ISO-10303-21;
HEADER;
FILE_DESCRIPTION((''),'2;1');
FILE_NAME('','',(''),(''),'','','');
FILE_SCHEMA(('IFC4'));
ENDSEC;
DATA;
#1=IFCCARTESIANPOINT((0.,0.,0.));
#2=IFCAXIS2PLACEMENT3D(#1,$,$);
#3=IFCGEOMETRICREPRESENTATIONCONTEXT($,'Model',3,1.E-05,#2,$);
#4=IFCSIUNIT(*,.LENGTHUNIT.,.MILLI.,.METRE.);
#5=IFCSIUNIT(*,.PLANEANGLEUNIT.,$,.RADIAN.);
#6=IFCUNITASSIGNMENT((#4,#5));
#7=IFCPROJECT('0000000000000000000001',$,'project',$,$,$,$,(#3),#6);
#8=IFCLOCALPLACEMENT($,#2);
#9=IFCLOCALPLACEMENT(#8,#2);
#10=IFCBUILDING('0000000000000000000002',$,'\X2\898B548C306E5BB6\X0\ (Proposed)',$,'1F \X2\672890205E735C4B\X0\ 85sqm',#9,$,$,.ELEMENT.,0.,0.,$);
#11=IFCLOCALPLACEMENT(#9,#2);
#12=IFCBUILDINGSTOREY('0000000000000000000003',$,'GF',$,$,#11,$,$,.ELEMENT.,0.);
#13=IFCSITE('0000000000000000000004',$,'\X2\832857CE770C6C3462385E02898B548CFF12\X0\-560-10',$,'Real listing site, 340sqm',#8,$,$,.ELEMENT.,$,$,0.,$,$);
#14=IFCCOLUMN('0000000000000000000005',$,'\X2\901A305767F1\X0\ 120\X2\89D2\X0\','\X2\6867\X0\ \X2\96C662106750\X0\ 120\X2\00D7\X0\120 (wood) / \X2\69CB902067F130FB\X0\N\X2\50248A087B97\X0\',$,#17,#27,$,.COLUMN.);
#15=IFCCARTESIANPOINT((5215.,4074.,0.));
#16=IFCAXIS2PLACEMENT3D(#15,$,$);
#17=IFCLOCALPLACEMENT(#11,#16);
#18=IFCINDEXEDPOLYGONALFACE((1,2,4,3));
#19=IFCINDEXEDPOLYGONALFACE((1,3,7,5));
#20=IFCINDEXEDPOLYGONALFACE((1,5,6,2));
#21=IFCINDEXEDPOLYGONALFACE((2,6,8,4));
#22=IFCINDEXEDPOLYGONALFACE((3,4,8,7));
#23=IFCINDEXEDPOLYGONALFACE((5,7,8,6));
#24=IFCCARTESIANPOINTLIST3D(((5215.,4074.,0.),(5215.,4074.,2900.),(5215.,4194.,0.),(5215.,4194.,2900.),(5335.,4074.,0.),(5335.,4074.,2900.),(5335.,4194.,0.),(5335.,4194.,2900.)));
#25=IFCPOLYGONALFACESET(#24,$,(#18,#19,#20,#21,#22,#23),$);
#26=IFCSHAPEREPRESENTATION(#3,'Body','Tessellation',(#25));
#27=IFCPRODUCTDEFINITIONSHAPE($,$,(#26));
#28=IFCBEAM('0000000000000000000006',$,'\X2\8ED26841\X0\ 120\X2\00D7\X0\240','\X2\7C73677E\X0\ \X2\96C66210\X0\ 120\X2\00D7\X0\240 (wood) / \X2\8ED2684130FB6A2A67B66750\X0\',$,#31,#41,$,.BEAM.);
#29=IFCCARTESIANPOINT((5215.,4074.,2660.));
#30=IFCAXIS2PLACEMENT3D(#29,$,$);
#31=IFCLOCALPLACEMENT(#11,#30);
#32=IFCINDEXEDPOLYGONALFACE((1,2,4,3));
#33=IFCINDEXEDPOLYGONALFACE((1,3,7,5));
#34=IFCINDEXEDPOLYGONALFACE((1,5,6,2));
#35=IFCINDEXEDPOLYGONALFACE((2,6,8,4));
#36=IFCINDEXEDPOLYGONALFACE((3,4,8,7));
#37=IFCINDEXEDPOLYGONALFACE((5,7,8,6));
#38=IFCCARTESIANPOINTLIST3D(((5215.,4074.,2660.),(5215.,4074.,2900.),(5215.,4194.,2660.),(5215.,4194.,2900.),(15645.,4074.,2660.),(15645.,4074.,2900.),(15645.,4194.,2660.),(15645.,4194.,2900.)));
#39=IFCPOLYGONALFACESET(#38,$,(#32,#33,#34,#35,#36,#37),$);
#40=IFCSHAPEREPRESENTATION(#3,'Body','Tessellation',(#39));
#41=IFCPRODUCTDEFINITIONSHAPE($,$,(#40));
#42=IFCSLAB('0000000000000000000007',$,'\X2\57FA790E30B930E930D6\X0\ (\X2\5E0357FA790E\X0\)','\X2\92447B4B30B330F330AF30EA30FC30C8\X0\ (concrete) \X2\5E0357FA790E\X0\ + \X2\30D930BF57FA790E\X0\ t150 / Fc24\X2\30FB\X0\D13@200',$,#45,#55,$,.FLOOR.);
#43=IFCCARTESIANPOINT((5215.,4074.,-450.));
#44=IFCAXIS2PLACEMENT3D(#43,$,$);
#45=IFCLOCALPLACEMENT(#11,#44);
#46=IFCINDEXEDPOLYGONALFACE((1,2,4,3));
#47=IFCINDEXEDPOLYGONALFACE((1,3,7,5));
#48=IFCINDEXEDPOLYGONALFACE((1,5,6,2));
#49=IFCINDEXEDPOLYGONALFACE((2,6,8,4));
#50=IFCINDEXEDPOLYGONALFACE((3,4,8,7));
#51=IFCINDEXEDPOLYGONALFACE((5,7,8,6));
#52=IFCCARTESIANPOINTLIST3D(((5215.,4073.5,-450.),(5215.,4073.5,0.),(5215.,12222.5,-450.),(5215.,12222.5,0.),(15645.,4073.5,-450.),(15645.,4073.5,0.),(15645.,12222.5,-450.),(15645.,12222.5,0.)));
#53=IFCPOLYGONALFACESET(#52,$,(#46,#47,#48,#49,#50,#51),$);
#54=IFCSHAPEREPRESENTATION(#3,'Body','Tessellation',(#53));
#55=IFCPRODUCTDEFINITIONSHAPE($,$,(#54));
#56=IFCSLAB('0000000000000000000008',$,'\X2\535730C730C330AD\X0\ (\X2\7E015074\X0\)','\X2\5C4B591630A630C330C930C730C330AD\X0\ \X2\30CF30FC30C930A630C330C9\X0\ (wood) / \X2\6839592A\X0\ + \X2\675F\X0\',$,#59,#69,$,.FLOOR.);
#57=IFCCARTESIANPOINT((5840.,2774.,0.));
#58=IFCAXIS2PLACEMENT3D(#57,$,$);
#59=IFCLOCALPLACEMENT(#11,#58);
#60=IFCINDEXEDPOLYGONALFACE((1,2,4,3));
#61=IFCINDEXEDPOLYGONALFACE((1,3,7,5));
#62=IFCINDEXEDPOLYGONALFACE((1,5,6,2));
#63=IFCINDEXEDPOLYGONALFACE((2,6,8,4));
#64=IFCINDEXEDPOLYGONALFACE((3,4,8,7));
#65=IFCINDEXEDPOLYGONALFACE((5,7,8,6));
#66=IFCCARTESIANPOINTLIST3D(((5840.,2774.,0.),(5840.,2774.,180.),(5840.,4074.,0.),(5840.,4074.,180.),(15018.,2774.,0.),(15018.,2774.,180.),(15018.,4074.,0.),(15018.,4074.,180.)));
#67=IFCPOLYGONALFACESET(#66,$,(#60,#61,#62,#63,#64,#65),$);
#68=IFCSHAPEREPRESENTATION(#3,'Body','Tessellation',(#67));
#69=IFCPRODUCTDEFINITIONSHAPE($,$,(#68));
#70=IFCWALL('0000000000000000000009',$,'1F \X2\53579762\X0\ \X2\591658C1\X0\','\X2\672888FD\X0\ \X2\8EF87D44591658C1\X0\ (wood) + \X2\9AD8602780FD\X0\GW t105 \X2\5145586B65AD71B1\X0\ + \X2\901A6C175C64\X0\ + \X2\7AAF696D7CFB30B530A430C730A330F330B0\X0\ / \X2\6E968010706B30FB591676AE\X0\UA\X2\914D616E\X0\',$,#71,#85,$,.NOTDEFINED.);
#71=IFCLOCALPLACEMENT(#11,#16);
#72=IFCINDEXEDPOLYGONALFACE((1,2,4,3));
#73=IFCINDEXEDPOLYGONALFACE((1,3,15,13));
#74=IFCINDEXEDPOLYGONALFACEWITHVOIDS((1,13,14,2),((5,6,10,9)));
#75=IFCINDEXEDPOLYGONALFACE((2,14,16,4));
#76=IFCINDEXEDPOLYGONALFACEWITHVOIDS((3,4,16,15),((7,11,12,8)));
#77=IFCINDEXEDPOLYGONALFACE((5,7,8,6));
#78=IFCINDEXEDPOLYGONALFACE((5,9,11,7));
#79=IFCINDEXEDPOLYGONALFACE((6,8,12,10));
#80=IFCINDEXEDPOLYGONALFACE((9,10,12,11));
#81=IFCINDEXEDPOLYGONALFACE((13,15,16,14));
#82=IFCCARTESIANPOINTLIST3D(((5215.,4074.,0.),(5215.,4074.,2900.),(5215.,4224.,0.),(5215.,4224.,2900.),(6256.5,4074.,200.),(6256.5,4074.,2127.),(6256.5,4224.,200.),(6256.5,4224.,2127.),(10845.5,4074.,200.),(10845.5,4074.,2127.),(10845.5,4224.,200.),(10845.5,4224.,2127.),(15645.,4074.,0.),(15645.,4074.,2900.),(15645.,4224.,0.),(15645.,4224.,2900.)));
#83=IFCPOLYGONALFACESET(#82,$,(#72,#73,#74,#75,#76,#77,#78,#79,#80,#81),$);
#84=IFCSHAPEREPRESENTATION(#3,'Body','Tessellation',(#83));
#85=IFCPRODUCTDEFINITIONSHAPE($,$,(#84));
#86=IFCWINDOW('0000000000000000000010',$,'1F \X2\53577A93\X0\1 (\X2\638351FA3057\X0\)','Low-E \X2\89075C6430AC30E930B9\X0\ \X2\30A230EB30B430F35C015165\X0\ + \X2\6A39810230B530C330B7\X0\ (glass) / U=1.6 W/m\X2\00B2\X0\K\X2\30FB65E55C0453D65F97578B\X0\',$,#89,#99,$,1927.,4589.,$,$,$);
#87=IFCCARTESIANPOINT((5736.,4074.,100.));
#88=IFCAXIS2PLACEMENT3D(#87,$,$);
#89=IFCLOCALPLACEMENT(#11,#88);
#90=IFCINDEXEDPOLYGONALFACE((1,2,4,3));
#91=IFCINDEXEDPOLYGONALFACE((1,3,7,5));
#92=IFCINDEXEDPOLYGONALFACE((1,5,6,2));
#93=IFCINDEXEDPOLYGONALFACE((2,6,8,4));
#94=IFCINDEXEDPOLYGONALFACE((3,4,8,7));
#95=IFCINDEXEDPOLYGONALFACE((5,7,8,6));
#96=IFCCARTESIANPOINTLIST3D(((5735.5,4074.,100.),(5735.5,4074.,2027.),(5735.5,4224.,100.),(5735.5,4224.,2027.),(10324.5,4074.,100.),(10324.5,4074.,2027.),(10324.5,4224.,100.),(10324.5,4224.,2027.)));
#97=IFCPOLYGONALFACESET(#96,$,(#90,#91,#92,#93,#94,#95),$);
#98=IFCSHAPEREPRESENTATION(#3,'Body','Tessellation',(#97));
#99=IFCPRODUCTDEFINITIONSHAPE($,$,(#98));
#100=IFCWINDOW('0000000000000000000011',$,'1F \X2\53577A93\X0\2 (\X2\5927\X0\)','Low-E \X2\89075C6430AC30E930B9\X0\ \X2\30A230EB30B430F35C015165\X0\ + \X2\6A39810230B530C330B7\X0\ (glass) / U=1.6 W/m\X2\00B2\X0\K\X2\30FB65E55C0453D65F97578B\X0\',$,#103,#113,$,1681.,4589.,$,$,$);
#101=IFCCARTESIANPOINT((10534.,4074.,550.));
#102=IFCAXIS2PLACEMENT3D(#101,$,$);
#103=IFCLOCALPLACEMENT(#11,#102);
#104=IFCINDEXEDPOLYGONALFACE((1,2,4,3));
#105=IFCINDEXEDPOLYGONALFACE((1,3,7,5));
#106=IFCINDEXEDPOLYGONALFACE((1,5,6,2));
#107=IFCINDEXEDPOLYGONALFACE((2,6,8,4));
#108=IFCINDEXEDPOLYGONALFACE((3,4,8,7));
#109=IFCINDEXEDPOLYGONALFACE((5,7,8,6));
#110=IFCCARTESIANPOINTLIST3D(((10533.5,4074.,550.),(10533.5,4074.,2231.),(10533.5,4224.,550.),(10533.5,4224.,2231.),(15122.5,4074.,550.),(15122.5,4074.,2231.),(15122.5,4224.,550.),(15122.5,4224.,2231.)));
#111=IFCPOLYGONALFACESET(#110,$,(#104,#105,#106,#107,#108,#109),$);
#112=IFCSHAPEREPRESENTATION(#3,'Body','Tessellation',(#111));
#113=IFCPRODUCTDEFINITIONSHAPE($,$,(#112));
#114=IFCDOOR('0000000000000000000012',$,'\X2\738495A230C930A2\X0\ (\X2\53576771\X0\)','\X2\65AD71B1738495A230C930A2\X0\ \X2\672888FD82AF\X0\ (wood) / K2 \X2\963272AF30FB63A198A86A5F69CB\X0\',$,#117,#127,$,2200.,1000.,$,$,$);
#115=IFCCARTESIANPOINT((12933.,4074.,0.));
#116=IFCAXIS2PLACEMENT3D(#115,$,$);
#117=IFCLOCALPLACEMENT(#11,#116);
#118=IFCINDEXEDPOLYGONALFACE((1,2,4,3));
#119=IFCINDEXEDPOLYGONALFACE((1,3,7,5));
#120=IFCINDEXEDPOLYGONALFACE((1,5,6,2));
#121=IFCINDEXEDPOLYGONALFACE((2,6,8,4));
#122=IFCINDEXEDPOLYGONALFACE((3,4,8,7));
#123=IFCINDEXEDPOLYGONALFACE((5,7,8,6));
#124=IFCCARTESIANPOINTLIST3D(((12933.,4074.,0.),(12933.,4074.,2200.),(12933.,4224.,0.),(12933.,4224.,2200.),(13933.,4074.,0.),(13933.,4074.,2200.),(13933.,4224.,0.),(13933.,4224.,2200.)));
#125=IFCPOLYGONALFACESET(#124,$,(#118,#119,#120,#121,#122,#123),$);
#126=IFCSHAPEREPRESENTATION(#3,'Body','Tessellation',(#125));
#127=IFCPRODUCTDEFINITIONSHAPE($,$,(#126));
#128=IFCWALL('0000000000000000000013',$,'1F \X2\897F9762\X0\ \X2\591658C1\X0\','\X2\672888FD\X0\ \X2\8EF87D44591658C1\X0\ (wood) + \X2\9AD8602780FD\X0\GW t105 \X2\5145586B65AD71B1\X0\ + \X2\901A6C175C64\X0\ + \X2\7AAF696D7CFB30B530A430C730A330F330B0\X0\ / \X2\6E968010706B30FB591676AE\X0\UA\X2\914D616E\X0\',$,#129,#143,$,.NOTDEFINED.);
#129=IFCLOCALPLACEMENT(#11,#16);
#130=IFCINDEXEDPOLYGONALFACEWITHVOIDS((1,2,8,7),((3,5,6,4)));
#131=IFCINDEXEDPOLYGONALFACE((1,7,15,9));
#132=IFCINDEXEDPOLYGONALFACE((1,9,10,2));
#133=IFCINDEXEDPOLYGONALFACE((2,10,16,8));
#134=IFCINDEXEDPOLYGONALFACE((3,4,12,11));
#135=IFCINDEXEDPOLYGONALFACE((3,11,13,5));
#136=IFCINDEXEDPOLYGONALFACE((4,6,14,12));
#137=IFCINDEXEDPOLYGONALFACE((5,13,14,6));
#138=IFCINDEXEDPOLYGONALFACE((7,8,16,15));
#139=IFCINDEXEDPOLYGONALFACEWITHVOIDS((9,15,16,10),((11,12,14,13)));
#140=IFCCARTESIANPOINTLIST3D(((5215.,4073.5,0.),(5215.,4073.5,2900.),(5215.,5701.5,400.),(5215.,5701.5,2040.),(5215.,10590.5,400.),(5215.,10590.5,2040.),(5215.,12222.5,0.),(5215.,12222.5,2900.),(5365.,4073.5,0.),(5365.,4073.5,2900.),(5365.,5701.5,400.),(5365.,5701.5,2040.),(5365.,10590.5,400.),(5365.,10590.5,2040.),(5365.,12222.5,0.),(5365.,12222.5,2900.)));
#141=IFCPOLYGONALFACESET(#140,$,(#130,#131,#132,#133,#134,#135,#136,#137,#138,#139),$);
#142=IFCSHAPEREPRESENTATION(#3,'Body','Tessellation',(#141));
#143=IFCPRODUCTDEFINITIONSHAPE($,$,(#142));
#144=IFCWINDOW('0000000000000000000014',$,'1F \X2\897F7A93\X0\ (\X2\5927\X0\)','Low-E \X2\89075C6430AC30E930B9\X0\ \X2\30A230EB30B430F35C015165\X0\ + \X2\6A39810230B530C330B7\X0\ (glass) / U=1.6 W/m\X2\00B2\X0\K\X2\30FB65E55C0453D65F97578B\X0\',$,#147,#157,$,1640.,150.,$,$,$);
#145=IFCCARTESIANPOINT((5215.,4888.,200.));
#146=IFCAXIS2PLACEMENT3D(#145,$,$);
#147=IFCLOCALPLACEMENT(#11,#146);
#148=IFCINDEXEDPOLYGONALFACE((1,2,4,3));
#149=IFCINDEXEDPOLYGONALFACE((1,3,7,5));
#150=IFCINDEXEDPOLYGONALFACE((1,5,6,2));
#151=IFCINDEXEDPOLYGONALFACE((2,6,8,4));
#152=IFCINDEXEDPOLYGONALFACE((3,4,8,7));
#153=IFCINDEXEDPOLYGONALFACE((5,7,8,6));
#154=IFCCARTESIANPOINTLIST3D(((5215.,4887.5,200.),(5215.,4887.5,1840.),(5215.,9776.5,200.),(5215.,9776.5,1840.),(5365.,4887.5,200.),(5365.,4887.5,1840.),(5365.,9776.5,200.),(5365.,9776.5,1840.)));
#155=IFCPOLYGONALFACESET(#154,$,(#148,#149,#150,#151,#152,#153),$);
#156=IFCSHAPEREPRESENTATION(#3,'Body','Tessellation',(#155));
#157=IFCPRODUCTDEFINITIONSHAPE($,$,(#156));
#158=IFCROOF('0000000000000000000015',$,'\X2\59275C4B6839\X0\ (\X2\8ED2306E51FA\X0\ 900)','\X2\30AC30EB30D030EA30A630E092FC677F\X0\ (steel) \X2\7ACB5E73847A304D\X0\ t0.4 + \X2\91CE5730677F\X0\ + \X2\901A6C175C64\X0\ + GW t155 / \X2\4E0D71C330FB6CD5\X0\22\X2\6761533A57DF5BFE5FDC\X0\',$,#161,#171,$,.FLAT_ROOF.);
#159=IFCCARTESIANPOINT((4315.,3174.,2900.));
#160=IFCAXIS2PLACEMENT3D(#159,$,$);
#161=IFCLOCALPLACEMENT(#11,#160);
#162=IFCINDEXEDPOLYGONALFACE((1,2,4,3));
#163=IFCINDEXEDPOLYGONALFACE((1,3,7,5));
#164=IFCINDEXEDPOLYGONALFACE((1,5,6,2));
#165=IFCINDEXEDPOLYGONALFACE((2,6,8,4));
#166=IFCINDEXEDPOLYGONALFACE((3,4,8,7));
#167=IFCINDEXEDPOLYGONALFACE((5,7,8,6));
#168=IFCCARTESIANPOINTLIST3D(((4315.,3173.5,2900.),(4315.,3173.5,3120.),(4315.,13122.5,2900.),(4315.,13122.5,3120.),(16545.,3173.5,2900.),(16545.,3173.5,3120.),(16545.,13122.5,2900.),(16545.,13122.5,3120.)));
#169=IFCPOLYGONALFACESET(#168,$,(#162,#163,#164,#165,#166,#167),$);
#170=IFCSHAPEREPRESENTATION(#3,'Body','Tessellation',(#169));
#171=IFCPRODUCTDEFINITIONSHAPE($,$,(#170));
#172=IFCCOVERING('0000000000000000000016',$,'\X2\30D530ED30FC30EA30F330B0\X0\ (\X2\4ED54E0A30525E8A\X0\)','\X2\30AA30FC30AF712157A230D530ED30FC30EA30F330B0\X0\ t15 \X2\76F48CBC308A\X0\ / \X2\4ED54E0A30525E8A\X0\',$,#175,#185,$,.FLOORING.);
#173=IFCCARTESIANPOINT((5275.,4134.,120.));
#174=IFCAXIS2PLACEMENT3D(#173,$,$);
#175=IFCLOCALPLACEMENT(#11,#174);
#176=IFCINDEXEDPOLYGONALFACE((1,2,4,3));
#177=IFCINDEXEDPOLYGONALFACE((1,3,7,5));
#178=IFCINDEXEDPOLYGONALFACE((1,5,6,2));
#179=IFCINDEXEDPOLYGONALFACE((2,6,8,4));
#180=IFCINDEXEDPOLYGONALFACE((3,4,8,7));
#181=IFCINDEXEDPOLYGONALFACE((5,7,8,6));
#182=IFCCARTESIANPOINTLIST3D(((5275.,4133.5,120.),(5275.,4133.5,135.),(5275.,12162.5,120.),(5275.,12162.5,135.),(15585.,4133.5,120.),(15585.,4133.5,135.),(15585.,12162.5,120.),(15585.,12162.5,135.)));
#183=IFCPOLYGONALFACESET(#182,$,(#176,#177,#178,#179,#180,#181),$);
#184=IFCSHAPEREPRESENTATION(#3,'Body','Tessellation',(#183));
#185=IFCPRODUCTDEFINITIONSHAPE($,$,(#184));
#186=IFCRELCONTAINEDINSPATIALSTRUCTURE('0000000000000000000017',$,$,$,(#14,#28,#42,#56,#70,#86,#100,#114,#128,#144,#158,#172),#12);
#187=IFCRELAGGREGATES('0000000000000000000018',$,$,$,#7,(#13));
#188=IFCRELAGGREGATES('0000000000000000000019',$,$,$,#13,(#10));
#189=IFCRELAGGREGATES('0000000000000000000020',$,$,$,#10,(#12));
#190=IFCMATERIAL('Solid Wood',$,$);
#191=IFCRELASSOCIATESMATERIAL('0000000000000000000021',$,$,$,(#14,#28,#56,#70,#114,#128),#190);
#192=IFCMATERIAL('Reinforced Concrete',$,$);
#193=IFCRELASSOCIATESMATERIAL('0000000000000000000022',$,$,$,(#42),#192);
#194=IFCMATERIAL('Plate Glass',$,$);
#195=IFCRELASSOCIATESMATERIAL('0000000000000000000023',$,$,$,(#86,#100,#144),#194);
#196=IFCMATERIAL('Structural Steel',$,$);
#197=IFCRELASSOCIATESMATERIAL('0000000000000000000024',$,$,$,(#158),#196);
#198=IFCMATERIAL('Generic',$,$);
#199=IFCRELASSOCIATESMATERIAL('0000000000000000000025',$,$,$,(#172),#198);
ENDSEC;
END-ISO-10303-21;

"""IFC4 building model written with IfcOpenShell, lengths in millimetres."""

from ifc_helpers import new_model, si_unit, frame, frame_2d, origin, place, context, project, spatial, rectangle, extrude, material, element, fill, save


model = new_model("IFC4")

# Units and contexts
model_context = context("Model", 3, precision=1e-05, world=origin())
ifc_project = project(units=[si_unit("LENGTHUNIT", "METRE", prefix="MILLI"), si_unit("PLANEANGLEUNIT", "RADIAN")], contexts=[model_context])

# Site, building, storey
site_placement = place(None, origin())
site = spatial("IfcSite", under=ifc_project, at=site_placement, Name="茨城県水戸市見和２-560-10", ObjectType="Real listing site, 340sqm", CompositionType="ELEMENT", RefElevation=0.0)
building_placement = place(site_placement, origin())
building = spatial("IfcBuilding", under=site, at=building_placement, Name="見和の家 (Proposed)", ObjectType="1F 木造平屋 85sqm", CompositionType="ELEMENT", ElevationOfRefHeight=0.0, ElevationOfTerrain=0.0)
storey_placement = place(building_placement, origin())
storey = spatial("IfcBuildingStorey", under=building, at=storey_placement, Name="GF", CompositionType="ELEMENT", Elevation=0.0)

# Column
ifc_material_1 = material(Name="Solid Wood")
column_placement = place(storey_placement, frame((5215.0, 4074.0, 0.0)))
element("IfcColumn", 1, at=column_placement, inside=storey, material=ifc_material_1, Name="通し柱 120角", Description="桧 集成材 120×120 (wood) / 構造柱・N値計算", PredefinedType="COLUMN", context=model_context, shape_type="SweptSolid", body=[
    extrude(rectangle(XDim=120.0, YDim=120.0, at=frame_2d((60.0, 60.0))), frame((5215.0, 4074.0, 0.0)), (0.0, 0.0, 1.0), 2900.0),
])

# Beam
beam_1_placement = place(storey_placement, frame((5215.0, 4074.0, 2660.0)))
element("IfcBeam", 2, at=beam_1_placement, inside=storey, material=ifc_material_1, Name="軒桁 120×240", Description="米松 集成 120×240 (wood) / 軒桁・横架材", PredefinedType="BEAM", context=model_context, shape_type="SweptSolid", body=[
    extrude(rectangle(XDim=10430.0, YDim=120.0, at=frame_2d((5215.0, 60.0))), frame((5215.0, 4074.0, 2660.0)), (0.0, 0.0, 1.0), 240.0),
])

# Slabs
ifc_material_2 = material(Name="Reinforced Concrete")
slab_1_placement = place(storey_placement, frame((5215.0, 4074.0, -450.0)))
element("IfcSlab", 3, at=slab_1_placement, inside=storey, material=ifc_material_2, Name="基礎スラブ (布基礎)", Description="鉄筋コンクリート (concrete) 布基礎 + ベタ基礎 t150 / Fc24・D13@200", PredefinedType="FLOOR", context=model_context, shape_type="SweptSolid", body=[
    extrude(rectangle(XDim=10430.0, YDim=8149.0, at=frame_2d((5215.0, 4074.0))), frame((5215.0, 4074.0, -450.0)), (0.0, 0.0, 1.0), 450.0),
])
slab_2_placement = place(storey_placement, frame((5840.0, 2774.0, 0.0)))
element("IfcSlab", 4, at=slab_2_placement, inside=storey, material=ifc_material_1, Name="南デッキ (縁側)", Description="屋外ウッドデッキ ハードウッド (wood) / 根太 + 束", PredefinedType="FLOOR", context=model_context, shape_type="SweptSolid", body=[
    extrude(rectangle(XDim=9178.0, YDim=1300.0, at=frame_2d((4589.0, 650.0))), frame((5840.0, 2774.0, 0.0)), (0.0, 0.0, 1.0), 180.0),
])

# Wall, openings, windows, door
wall_1_placement = place(storey_placement, frame((5215.0, 4074.0, 0.0)))
wall_1 = element("IfcWall", 5, at=wall_1_placement, inside=storey, material=ifc_material_1, Name="1F 南面 外壁", Description="木製 軸組外壁 (wood) + 高性能GW t105 充填断熱 + 通気層 + 窯業系サイディング / 準耐火・外皮UA配慮", PredefinedType="NOTDEFINED", context=model_context, shape_type="SweptSolid", body=[
    extrude(rectangle(XDim=10430.0, YDim=150.0, at=frame_2d((5215.0, 75.0))), frame((5215.0, 4074.0, 0.0)), (0.0, 0.0, 1.0), 2900.0),
])
opening_1_placement = place(storey_placement, frame((5736.0, 4074.0, 100.0)))
opening_1 = element("IfcOpeningElement", 6, at=opening_1_placement, cuts=wall_1, PredefinedType="NOTDEFINED", context=model_context, shape_type="SweptSolid", body=[
    extrude(rectangle(XDim=4589.0, YDim=150.0, at=frame_2d((2294.0, 75.0))), frame((5736.0, 4074.0, 100.0)), (0.0, 0.0, 1.0), 1927.0),
])
opening_2_placement = place(storey_placement, frame((10534.0, 4074.0, 550.0)))
opening_2 = element("IfcOpeningElement", 7, at=opening_2_placement, cuts=wall_1, PredefinedType="NOTDEFINED", context=model_context, shape_type="SweptSolid", body=[
    extrude(rectangle(XDim=4589.0, YDim=150.0, at=frame_2d((2294.0, 75.0))), frame((10534.0, 4074.0, 550.0)), (0.0, 0.0, 1.0), 1681.0),
])
opening_3_placement = place(storey_placement, frame((12933.0, 4074.0, 0.0)))
opening_3 = element("IfcOpeningElement", 8, at=opening_3_placement, cuts=wall_1, PredefinedType="NOTDEFINED", context=model_context, shape_type="SweptSolid", body=[
    extrude(rectangle(XDim=1000.0, YDim=150.0, at=frame_2d((500.0, 75.0))), frame((12933.0, 4074.0, 0.0)), (0.0, 0.0, 1.0), 2200.0),
])
ifc_material_3 = material(Name="Plate Glass")
window_1_placement = place(storey_placement, frame((5736.0, 4074.0, 100.0)))
window_1 = element("IfcWindow", 9, at=window_1_placement, inside=storey, material=ifc_material_3, Name="1F 南窓1 (掃出し)", Description="Low-E 複層ガラス アルゴン封入 + 樹脂サッシ (glass) / U=1.6 W/m²K・日射取得型", OverallHeight=1927.0, OverallWidth=4589.0, context=model_context, shape_type="SweptSolid", body=[
    extrude(rectangle(XDim=4589.0, YDim=150.0, at=frame_2d((2294.0, 75.0))), frame((5736.0, 4074.0, 100.0)), (0.0, 0.0, 1.0), 1927.0),
])
fill(opening_1, window_1)
window_2_placement = place(storey_placement, frame((10534.0, 4074.0, 550.0)))
window_2 = element("IfcWindow", 10, at=window_2_placement, inside=storey, material=ifc_material_3, Name="1F 南窓2 (大)", Description="Low-E 複層ガラス アルゴン封入 + 樹脂サッシ (glass) / U=1.6 W/m²K・日射取得型", OverallHeight=1681.0, OverallWidth=4589.0, context=model_context, shape_type="SweptSolid", body=[
    extrude(rectangle(XDim=4589.0, YDim=150.0, at=frame_2d((2294.0, 75.0))), frame((10534.0, 4074.0, 550.0)), (0.0, 0.0, 1.0), 1681.0),
])
fill(opening_2, window_2)
door_placement = place(storey_placement, frame((12933.0, 4074.0, 0.0)))
door = element("IfcDoor", 11, at=door_placement, inside=storey, material=ifc_material_1, Name="玄関ドア (南東)", Description="断熱玄関ドア 木製芯 (wood) / K2 防犯・採風機構", OverallHeight=2200.0, OverallWidth=1000.0, context=model_context, shape_type="SweptSolid", body=[
    extrude(rectangle(XDim=1000.0, YDim=150.0, at=frame_2d((500.0, 75.0))), frame((12933.0, 4074.0, 0.0)), (0.0, 0.0, 1.0), 2200.0),
])
fill(opening_3, door)

# Wall, opening, window
wall_2_placement = place(storey_placement, frame((5215.0, 4074.0, 0.0)))
wall_2 = element("IfcWall", 12, at=wall_2_placement, inside=storey, material=ifc_material_1, Name="1F 西面 外壁", Description="木製 軸組外壁 (wood) + 高性能GW t105 充填断熱 + 通気層 + 窯業系サイディング / 準耐火・外皮UA配慮", PredefinedType="NOTDEFINED", context=model_context, shape_type="SweptSolid", body=[
    extrude(rectangle(XDim=150.0, YDim=8149.0, at=frame_2d((75.0, 4074.0))), frame((5215.0, 4074.0, 0.0)), (0.0, 0.0, 1.0), 2900.0),
])
opening_4_placement = place(storey_placement, frame((5215.0, 4888.0, 200.0)))
opening_4 = element("IfcOpeningElement", 13, at=opening_4_placement, cuts=wall_2, PredefinedType="NOTDEFINED", context=model_context, shape_type="SweptSolid", body=[
    extrude(rectangle(XDim=150.0, YDim=4889.0, at=frame_2d((75.0, 2444.0))), frame((5215.0, 4888.0, 200.0)), (0.0, 0.0, 1.0), 1640.0),
])
window_3_placement = place(storey_placement, frame((5215.0, 4888.0, 200.0)))
window_3 = element("IfcWindow", 14, at=window_3_placement, inside=storey, material=ifc_material_3, Name="1F 西窓 (大)", Description="Low-E 複層ガラス アルゴン封入 + 樹脂サッシ (glass) / U=1.6 W/m²K・日射取得型", OverallHeight=1640.0, OverallWidth=150.0, context=model_context, shape_type="SweptSolid", body=[
    extrude(rectangle(XDim=150.0, YDim=4889.0, at=frame_2d((75.0, 2444.0))), frame((5215.0, 4888.0, 200.0)), (0.0, 0.0, 1.0), 1640.0),
])
fill(opening_4, window_3)

# Roof
ifc_material_4 = material(Name="Structural Steel")
roof_placement = place(storey_placement, frame((4315.0, 3174.0, 2900.0)))
element("IfcRoof", 15, at=roof_placement, inside=storey, material=ifc_material_4, Name="大屋根 (軒の出 900)", Description="ガルバリウム鋼板 (steel) 立平葺き t0.4 + 野地板 + 通気層 + GW t155 / 不燃・法22条区域対応", PredefinedType="FLAT_ROOF", context=model_context, shape_type="SweptSolid", body=[
    extrude(rectangle(XDim=12230.0, YDim=9949.0, at=frame_2d((6115.0, 4974.0))), frame((4315.0, 3174.0, 2900.0)), (0.0, 0.0, 1.0), 220.0),
])

# Covering
ifc_material_5 = material(Name="Generic")
covering_1_placement = place(storey_placement, frame((5275.0, 4134.0, 120.0)))
element("IfcCovering", 16, at=covering_1_placement, inside=storey, material=ifc_material_5, Name="フローリング (仕上げ床)", Description="オーク無垢フローリング t15 直貼り / 仕上げ床", PredefinedType="FLOORING", context=model_context, shape_type="SweptSolid", body=[
    extrude(rectangle(XDim=10310.0, YDim=8029.0, at=frame_2d((5155.0, 4014.0))), frame((5275.0, 4134.0, 120.0)), (0.0, 0.0, 1.0), 15.0),
])

save(model, "model.ifc")
